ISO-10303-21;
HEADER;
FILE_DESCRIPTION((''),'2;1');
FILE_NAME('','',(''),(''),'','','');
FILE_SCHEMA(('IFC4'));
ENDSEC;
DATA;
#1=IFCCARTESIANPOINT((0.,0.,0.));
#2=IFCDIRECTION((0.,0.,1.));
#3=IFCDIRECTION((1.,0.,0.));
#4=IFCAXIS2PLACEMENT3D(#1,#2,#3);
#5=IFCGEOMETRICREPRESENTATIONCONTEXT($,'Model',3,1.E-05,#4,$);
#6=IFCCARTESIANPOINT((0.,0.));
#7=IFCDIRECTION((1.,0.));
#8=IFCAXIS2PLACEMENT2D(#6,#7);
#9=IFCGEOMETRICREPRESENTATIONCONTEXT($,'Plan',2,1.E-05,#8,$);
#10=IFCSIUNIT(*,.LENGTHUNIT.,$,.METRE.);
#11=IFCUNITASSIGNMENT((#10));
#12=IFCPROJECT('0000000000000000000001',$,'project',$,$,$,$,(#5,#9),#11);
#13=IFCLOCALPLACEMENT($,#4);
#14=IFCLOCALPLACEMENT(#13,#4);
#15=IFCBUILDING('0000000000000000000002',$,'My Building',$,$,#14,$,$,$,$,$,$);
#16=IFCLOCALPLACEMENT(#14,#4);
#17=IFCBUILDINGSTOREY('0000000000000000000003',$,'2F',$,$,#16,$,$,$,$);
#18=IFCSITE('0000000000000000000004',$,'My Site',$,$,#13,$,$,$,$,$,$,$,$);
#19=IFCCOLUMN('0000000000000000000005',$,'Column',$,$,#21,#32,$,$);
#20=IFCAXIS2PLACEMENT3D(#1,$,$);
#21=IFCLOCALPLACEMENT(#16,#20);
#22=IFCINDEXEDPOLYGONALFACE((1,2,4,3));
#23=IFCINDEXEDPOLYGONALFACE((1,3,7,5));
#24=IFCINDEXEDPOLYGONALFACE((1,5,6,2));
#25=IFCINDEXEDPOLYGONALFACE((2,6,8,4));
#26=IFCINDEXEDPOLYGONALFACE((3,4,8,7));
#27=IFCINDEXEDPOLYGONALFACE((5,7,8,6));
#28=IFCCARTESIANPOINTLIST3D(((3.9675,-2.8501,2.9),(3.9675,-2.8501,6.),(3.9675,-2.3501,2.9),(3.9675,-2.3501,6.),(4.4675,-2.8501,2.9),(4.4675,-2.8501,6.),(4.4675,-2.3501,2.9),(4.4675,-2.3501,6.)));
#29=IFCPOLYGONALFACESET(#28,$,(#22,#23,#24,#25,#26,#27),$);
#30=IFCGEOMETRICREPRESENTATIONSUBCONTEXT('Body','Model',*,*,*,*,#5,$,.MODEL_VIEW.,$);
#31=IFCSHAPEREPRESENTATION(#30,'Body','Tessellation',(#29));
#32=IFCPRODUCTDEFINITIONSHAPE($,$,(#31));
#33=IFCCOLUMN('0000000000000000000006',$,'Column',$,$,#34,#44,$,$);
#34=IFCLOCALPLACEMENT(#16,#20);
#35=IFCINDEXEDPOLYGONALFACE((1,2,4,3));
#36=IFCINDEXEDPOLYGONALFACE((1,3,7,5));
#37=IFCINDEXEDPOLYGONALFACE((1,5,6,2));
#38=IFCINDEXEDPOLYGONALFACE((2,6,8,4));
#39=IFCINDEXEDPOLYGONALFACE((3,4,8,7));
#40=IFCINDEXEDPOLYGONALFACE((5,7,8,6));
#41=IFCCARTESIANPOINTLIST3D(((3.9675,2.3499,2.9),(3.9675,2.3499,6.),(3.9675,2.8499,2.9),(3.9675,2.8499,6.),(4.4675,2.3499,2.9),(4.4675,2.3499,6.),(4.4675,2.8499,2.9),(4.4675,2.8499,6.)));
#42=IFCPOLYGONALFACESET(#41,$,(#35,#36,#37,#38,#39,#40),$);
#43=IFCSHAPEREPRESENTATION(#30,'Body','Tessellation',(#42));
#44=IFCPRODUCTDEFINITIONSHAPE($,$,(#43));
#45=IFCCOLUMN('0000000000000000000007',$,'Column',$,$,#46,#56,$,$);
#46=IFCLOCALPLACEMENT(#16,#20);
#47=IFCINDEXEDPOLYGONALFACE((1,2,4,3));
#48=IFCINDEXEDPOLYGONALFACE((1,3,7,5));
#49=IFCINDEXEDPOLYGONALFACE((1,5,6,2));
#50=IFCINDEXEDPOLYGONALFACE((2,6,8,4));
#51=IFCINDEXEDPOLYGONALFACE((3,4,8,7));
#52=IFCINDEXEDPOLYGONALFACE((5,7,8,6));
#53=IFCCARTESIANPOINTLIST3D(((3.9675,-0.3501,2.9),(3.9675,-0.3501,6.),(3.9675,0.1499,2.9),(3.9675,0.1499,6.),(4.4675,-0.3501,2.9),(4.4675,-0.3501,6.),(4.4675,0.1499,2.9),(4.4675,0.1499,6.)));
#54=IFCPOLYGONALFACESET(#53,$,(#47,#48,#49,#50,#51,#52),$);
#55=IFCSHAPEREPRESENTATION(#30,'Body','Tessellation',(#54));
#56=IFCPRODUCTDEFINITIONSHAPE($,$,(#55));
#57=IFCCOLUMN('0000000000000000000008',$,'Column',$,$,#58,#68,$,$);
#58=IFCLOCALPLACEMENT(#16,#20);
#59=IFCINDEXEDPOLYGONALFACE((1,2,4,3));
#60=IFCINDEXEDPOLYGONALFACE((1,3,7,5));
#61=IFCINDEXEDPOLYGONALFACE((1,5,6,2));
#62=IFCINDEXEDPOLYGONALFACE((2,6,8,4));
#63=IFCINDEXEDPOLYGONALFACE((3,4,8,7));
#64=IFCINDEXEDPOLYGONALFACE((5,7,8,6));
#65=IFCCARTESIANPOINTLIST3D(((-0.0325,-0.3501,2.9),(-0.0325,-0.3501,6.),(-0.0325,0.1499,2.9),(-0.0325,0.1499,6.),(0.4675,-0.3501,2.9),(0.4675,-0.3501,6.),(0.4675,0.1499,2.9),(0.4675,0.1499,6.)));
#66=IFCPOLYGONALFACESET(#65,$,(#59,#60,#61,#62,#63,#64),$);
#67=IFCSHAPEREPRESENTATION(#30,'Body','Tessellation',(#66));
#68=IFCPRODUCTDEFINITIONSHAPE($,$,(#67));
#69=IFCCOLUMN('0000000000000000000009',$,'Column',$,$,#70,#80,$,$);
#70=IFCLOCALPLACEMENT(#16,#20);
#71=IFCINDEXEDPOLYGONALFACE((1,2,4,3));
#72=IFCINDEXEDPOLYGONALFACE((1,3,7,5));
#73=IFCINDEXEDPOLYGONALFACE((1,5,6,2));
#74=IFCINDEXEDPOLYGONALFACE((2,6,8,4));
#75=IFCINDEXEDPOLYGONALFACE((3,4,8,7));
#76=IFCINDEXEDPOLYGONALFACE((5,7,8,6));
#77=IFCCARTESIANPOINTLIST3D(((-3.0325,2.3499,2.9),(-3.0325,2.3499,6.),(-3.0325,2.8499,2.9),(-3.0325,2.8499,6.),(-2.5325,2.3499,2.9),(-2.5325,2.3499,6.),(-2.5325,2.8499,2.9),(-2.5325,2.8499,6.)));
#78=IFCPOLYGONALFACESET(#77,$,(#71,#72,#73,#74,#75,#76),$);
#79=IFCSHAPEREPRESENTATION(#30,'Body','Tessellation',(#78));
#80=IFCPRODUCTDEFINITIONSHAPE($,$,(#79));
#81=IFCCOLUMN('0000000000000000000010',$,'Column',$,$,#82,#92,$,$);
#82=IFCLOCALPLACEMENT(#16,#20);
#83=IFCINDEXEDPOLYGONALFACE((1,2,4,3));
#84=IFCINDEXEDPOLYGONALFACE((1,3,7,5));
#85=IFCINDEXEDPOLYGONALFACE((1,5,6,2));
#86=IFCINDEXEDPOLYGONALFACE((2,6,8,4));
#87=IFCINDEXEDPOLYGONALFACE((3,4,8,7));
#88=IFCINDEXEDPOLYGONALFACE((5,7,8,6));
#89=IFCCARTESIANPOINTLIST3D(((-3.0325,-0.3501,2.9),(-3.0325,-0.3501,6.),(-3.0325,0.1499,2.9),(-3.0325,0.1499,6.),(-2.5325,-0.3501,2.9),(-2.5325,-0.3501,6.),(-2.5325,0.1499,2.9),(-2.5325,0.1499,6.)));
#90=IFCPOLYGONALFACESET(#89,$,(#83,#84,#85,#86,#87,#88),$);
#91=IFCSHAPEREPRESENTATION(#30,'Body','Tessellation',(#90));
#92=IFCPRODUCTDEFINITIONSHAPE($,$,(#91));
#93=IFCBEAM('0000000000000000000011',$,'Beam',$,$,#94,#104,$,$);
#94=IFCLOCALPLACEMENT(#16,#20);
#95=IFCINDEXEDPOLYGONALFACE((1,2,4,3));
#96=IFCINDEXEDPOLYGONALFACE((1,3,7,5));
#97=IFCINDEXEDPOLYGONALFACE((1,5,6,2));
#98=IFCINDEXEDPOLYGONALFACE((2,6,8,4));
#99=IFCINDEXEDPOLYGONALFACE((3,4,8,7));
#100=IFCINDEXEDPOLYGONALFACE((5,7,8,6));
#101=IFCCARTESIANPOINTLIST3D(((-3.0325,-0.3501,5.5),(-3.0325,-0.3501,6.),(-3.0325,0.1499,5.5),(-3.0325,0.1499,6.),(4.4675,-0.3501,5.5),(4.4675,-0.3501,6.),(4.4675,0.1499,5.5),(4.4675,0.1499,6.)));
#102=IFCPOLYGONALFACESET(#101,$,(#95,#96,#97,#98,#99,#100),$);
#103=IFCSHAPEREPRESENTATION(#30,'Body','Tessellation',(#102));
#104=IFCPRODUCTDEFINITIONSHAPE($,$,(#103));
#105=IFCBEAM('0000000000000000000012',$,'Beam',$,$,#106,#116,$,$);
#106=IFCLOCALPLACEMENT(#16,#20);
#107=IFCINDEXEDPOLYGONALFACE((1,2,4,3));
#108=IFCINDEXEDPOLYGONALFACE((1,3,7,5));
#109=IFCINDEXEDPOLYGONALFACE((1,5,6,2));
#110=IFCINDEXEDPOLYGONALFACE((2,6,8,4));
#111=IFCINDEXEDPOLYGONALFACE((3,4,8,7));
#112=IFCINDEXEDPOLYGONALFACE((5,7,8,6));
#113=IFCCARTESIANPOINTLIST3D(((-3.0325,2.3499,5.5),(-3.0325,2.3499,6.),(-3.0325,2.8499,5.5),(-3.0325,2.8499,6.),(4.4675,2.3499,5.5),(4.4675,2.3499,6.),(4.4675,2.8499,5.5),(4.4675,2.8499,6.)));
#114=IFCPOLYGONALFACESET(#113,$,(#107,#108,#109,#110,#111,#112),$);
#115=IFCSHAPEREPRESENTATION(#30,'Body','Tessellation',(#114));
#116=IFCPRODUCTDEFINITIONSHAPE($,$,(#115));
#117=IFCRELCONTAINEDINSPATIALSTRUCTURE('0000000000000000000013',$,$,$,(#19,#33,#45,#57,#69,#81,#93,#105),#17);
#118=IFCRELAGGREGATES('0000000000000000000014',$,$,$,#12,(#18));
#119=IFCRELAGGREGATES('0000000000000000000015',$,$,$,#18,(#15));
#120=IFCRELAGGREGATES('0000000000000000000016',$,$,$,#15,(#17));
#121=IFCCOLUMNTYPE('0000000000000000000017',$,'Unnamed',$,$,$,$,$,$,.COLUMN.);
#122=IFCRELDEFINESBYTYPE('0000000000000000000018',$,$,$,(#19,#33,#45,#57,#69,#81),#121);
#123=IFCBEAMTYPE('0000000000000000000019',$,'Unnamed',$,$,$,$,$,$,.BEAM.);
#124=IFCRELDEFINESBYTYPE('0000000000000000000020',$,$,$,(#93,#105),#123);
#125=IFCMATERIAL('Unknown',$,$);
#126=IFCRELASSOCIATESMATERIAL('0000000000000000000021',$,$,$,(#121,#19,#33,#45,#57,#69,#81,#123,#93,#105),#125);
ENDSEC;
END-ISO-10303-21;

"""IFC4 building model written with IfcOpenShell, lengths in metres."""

from ifc_helpers import new_model, si_unit, frame, origin_with_axes, origin_2d_with_axis, place, context, subcontext, project, spatial, rectangle, extrude, material, material_profile, profile_set, profile_usage, type_object, element, save


model = new_model("IFC4")

# Units and contexts
model_context = context("Model", 3, precision=1e-05, world=origin_with_axes())
plan_context = context("Plan", 2, precision=1e-05, world=origin_2d_with_axis())
body_context_1 = subcontext(model_context, "Body", "Model", "MODEL_VIEW")
ifc_project = project(units=[si_unit("LENGTHUNIT", "METRE")], contexts=[model_context, plan_context])

# Site, building, storey
site_placement = place(None, origin_with_axes())
site = spatial("IfcSite", under=ifc_project, at=site_placement, Name="My Site")
building_placement = place(site_placement, origin_with_axes())
building = spatial("IfcBuilding", under=site, at=building_placement, Name="My Building")
storey_placement = place(building_placement, origin_with_axes())
storey = spatial("IfcBuildingStorey", under=building, at=storey_placement, Name="2F")

# Columns
ifc_material = material(Name="Unknown")
ifc_material_profile_1 = material_profile(ifc_material, rectangle(XDim=0.5, YDim=0.5))
ifc_profile_set_1 = profile_set([ifc_material_profile_1])
ifc_profile_usage_1 = profile_usage(ifc_profile_set_1, cardinal=5)
column_type = type_object("IfcColumnType", Name="Unnamed", PredefinedType="COLUMN", material=ifc_profile_set_1)
column_1_placement = place(storey_placement, frame((4.2175, -2.6001, 2.9), z_axis=(0.0, 0.0, 1.0), x_axis=(1.0, 0.0, 0.0)))
element("IfcColumn", 1, at=column_1_placement, inside=storey, type_object=column_type, material=ifc_profile_usage_1, Name="Column", context=body_context_1, shape_type="SweptSolid", body=[
    extrude(rectangle(XDim=0.5, YDim=0.5), origin_with_axes(), (0.0, 0.0, 1.0), 3.1),
])
ifc_profile_usage_2 = profile_usage(ifc_profile_set_1, cardinal=5)
column_2_placement = place(storey_placement, frame((4.2175, 2.5999, 2.9), z_axis=(0.0, 0.0, 1.0), x_axis=(1.0, 0.0, 0.0)))
element("IfcColumn", 2, at=column_2_placement, inside=storey, type_object=column_type, material=ifc_profile_usage_2, Name="Column", context=body_context_1, shape_type="SweptSolid", body=[
    extrude(rectangle(XDim=0.5, YDim=0.5), origin_with_axes(), (0.0, 0.0, 1.0), 3.1),
])
ifc_profile_usage_3 = profile_usage(ifc_profile_set_1, cardinal=5)
column_3_placement = place(storey_placement, frame((4.2175, -0.1001, 2.9), z_axis=(0.0, 0.0, 1.0), x_axis=(1.0, 0.0, 0.0)))
element("IfcColumn", 3, at=column_3_placement, inside=storey, type_object=column_type, material=ifc_profile_usage_3, Name="Column", context=body_context_1, shape_type="SweptSolid", body=[
    extrude(rectangle(XDim=0.5, YDim=0.5), origin_with_axes(), (0.0, 0.0, 1.0), 3.1),
])
ifc_profile_usage_4 = profile_usage(ifc_profile_set_1, cardinal=5)
column_4_placement = place(storey_placement, frame((0.2175, -0.1001, 2.9), z_axis=(0.0, 0.0, 1.0), x_axis=(1.0, 0.0, 0.0)))
element("IfcColumn", 4, at=column_4_placement, inside=storey, type_object=column_type, material=ifc_profile_usage_4, Name="Column", context=body_context_1, shape_type="SweptSolid", body=[
    extrude(rectangle(XDim=0.5, YDim=0.5), origin_with_axes(), (0.0, 0.0, 1.0), 3.1),
])
ifc_profile_usage_5 = profile_usage(ifc_profile_set_1, cardinal=5)
column_5_placement = place(storey_placement, frame((-2.7825, 2.5999, 2.9), z_axis=(0.0, 0.0, 1.0), x_axis=(1.0, 0.0, 0.0)))
element("IfcColumn", 5, at=column_5_placement, inside=storey, type_object=column_type, material=ifc_profile_usage_5, Name="Column", context=body_context_1, shape_type="SweptSolid", body=[
    extrude(rectangle(XDim=0.5, YDim=0.5), origin_with_axes(), (0.0, 0.0, 1.0), 3.1),
])
ifc_profile_usage_6 = profile_usage(ifc_profile_set_1, cardinal=5)
column_6_placement = place(storey_placement, frame((-2.7825, -0.1001, 2.9), z_axis=(0.0, 0.0, 1.0), x_axis=(1.0, 0.0, 0.0)))
element("IfcColumn", 6, at=column_6_placement, inside=storey, type_object=column_type, material=ifc_profile_usage_6, Name="Column", context=body_context_1, shape_type="SweptSolid", body=[
    extrude(rectangle(XDim=0.5, YDim=0.5), origin_with_axes(), (0.0, 0.0, 1.0), 3.1),
])

# Beams
ifc_material_profile_2 = material_profile(ifc_material, rectangle(XDim=0.5, YDim=0.5))
ifc_profile_set_2 = profile_set([ifc_material_profile_2])
ifc_profile_usage_7 = profile_usage(ifc_profile_set_2, cardinal=5)
beam_type = type_object("IfcBeamType", Name="Unnamed", PredefinedType="BEAM", material=ifc_profile_set_2)
beam_1_placement = place(storey_placement, frame((-3.0325, -0.1001, 5.75), z_axis=(1.0, 0.0, 0.0), x_axis=(0.0, 1.0, 0.0)))
element("IfcBeam", 7, at=beam_1_placement, inside=storey, type_object=beam_type, material=ifc_profile_usage_7, Name="Beam", context=body_context_1, shape_type="SweptSolid", body=[
    extrude(rectangle(XDim=0.5, YDim=0.5), origin_with_axes(), (0.0, 0.0, 1.0), 7.5),
])
ifc_profile_usage_8 = profile_usage(ifc_profile_set_2, cardinal=5)
beam_2_placement = place(storey_placement, frame((-3.0325, 2.5999, 5.75), z_axis=(1.0, 0.0, 0.0), x_axis=(0.0, 1.0, 0.0)))
element("IfcBeam", 8, at=beam_2_placement, inside=storey, type_object=beam_type, material=ifc_profile_usage_8, Name="Beam", context=body_context_1, shape_type="SweptSolid", body=[
    extrude(rectangle(XDim=0.5, YDim=0.5), origin_with_axes(), (0.0, 0.0, 1.0), 7.5),
])

save(model, "model.ifc")
